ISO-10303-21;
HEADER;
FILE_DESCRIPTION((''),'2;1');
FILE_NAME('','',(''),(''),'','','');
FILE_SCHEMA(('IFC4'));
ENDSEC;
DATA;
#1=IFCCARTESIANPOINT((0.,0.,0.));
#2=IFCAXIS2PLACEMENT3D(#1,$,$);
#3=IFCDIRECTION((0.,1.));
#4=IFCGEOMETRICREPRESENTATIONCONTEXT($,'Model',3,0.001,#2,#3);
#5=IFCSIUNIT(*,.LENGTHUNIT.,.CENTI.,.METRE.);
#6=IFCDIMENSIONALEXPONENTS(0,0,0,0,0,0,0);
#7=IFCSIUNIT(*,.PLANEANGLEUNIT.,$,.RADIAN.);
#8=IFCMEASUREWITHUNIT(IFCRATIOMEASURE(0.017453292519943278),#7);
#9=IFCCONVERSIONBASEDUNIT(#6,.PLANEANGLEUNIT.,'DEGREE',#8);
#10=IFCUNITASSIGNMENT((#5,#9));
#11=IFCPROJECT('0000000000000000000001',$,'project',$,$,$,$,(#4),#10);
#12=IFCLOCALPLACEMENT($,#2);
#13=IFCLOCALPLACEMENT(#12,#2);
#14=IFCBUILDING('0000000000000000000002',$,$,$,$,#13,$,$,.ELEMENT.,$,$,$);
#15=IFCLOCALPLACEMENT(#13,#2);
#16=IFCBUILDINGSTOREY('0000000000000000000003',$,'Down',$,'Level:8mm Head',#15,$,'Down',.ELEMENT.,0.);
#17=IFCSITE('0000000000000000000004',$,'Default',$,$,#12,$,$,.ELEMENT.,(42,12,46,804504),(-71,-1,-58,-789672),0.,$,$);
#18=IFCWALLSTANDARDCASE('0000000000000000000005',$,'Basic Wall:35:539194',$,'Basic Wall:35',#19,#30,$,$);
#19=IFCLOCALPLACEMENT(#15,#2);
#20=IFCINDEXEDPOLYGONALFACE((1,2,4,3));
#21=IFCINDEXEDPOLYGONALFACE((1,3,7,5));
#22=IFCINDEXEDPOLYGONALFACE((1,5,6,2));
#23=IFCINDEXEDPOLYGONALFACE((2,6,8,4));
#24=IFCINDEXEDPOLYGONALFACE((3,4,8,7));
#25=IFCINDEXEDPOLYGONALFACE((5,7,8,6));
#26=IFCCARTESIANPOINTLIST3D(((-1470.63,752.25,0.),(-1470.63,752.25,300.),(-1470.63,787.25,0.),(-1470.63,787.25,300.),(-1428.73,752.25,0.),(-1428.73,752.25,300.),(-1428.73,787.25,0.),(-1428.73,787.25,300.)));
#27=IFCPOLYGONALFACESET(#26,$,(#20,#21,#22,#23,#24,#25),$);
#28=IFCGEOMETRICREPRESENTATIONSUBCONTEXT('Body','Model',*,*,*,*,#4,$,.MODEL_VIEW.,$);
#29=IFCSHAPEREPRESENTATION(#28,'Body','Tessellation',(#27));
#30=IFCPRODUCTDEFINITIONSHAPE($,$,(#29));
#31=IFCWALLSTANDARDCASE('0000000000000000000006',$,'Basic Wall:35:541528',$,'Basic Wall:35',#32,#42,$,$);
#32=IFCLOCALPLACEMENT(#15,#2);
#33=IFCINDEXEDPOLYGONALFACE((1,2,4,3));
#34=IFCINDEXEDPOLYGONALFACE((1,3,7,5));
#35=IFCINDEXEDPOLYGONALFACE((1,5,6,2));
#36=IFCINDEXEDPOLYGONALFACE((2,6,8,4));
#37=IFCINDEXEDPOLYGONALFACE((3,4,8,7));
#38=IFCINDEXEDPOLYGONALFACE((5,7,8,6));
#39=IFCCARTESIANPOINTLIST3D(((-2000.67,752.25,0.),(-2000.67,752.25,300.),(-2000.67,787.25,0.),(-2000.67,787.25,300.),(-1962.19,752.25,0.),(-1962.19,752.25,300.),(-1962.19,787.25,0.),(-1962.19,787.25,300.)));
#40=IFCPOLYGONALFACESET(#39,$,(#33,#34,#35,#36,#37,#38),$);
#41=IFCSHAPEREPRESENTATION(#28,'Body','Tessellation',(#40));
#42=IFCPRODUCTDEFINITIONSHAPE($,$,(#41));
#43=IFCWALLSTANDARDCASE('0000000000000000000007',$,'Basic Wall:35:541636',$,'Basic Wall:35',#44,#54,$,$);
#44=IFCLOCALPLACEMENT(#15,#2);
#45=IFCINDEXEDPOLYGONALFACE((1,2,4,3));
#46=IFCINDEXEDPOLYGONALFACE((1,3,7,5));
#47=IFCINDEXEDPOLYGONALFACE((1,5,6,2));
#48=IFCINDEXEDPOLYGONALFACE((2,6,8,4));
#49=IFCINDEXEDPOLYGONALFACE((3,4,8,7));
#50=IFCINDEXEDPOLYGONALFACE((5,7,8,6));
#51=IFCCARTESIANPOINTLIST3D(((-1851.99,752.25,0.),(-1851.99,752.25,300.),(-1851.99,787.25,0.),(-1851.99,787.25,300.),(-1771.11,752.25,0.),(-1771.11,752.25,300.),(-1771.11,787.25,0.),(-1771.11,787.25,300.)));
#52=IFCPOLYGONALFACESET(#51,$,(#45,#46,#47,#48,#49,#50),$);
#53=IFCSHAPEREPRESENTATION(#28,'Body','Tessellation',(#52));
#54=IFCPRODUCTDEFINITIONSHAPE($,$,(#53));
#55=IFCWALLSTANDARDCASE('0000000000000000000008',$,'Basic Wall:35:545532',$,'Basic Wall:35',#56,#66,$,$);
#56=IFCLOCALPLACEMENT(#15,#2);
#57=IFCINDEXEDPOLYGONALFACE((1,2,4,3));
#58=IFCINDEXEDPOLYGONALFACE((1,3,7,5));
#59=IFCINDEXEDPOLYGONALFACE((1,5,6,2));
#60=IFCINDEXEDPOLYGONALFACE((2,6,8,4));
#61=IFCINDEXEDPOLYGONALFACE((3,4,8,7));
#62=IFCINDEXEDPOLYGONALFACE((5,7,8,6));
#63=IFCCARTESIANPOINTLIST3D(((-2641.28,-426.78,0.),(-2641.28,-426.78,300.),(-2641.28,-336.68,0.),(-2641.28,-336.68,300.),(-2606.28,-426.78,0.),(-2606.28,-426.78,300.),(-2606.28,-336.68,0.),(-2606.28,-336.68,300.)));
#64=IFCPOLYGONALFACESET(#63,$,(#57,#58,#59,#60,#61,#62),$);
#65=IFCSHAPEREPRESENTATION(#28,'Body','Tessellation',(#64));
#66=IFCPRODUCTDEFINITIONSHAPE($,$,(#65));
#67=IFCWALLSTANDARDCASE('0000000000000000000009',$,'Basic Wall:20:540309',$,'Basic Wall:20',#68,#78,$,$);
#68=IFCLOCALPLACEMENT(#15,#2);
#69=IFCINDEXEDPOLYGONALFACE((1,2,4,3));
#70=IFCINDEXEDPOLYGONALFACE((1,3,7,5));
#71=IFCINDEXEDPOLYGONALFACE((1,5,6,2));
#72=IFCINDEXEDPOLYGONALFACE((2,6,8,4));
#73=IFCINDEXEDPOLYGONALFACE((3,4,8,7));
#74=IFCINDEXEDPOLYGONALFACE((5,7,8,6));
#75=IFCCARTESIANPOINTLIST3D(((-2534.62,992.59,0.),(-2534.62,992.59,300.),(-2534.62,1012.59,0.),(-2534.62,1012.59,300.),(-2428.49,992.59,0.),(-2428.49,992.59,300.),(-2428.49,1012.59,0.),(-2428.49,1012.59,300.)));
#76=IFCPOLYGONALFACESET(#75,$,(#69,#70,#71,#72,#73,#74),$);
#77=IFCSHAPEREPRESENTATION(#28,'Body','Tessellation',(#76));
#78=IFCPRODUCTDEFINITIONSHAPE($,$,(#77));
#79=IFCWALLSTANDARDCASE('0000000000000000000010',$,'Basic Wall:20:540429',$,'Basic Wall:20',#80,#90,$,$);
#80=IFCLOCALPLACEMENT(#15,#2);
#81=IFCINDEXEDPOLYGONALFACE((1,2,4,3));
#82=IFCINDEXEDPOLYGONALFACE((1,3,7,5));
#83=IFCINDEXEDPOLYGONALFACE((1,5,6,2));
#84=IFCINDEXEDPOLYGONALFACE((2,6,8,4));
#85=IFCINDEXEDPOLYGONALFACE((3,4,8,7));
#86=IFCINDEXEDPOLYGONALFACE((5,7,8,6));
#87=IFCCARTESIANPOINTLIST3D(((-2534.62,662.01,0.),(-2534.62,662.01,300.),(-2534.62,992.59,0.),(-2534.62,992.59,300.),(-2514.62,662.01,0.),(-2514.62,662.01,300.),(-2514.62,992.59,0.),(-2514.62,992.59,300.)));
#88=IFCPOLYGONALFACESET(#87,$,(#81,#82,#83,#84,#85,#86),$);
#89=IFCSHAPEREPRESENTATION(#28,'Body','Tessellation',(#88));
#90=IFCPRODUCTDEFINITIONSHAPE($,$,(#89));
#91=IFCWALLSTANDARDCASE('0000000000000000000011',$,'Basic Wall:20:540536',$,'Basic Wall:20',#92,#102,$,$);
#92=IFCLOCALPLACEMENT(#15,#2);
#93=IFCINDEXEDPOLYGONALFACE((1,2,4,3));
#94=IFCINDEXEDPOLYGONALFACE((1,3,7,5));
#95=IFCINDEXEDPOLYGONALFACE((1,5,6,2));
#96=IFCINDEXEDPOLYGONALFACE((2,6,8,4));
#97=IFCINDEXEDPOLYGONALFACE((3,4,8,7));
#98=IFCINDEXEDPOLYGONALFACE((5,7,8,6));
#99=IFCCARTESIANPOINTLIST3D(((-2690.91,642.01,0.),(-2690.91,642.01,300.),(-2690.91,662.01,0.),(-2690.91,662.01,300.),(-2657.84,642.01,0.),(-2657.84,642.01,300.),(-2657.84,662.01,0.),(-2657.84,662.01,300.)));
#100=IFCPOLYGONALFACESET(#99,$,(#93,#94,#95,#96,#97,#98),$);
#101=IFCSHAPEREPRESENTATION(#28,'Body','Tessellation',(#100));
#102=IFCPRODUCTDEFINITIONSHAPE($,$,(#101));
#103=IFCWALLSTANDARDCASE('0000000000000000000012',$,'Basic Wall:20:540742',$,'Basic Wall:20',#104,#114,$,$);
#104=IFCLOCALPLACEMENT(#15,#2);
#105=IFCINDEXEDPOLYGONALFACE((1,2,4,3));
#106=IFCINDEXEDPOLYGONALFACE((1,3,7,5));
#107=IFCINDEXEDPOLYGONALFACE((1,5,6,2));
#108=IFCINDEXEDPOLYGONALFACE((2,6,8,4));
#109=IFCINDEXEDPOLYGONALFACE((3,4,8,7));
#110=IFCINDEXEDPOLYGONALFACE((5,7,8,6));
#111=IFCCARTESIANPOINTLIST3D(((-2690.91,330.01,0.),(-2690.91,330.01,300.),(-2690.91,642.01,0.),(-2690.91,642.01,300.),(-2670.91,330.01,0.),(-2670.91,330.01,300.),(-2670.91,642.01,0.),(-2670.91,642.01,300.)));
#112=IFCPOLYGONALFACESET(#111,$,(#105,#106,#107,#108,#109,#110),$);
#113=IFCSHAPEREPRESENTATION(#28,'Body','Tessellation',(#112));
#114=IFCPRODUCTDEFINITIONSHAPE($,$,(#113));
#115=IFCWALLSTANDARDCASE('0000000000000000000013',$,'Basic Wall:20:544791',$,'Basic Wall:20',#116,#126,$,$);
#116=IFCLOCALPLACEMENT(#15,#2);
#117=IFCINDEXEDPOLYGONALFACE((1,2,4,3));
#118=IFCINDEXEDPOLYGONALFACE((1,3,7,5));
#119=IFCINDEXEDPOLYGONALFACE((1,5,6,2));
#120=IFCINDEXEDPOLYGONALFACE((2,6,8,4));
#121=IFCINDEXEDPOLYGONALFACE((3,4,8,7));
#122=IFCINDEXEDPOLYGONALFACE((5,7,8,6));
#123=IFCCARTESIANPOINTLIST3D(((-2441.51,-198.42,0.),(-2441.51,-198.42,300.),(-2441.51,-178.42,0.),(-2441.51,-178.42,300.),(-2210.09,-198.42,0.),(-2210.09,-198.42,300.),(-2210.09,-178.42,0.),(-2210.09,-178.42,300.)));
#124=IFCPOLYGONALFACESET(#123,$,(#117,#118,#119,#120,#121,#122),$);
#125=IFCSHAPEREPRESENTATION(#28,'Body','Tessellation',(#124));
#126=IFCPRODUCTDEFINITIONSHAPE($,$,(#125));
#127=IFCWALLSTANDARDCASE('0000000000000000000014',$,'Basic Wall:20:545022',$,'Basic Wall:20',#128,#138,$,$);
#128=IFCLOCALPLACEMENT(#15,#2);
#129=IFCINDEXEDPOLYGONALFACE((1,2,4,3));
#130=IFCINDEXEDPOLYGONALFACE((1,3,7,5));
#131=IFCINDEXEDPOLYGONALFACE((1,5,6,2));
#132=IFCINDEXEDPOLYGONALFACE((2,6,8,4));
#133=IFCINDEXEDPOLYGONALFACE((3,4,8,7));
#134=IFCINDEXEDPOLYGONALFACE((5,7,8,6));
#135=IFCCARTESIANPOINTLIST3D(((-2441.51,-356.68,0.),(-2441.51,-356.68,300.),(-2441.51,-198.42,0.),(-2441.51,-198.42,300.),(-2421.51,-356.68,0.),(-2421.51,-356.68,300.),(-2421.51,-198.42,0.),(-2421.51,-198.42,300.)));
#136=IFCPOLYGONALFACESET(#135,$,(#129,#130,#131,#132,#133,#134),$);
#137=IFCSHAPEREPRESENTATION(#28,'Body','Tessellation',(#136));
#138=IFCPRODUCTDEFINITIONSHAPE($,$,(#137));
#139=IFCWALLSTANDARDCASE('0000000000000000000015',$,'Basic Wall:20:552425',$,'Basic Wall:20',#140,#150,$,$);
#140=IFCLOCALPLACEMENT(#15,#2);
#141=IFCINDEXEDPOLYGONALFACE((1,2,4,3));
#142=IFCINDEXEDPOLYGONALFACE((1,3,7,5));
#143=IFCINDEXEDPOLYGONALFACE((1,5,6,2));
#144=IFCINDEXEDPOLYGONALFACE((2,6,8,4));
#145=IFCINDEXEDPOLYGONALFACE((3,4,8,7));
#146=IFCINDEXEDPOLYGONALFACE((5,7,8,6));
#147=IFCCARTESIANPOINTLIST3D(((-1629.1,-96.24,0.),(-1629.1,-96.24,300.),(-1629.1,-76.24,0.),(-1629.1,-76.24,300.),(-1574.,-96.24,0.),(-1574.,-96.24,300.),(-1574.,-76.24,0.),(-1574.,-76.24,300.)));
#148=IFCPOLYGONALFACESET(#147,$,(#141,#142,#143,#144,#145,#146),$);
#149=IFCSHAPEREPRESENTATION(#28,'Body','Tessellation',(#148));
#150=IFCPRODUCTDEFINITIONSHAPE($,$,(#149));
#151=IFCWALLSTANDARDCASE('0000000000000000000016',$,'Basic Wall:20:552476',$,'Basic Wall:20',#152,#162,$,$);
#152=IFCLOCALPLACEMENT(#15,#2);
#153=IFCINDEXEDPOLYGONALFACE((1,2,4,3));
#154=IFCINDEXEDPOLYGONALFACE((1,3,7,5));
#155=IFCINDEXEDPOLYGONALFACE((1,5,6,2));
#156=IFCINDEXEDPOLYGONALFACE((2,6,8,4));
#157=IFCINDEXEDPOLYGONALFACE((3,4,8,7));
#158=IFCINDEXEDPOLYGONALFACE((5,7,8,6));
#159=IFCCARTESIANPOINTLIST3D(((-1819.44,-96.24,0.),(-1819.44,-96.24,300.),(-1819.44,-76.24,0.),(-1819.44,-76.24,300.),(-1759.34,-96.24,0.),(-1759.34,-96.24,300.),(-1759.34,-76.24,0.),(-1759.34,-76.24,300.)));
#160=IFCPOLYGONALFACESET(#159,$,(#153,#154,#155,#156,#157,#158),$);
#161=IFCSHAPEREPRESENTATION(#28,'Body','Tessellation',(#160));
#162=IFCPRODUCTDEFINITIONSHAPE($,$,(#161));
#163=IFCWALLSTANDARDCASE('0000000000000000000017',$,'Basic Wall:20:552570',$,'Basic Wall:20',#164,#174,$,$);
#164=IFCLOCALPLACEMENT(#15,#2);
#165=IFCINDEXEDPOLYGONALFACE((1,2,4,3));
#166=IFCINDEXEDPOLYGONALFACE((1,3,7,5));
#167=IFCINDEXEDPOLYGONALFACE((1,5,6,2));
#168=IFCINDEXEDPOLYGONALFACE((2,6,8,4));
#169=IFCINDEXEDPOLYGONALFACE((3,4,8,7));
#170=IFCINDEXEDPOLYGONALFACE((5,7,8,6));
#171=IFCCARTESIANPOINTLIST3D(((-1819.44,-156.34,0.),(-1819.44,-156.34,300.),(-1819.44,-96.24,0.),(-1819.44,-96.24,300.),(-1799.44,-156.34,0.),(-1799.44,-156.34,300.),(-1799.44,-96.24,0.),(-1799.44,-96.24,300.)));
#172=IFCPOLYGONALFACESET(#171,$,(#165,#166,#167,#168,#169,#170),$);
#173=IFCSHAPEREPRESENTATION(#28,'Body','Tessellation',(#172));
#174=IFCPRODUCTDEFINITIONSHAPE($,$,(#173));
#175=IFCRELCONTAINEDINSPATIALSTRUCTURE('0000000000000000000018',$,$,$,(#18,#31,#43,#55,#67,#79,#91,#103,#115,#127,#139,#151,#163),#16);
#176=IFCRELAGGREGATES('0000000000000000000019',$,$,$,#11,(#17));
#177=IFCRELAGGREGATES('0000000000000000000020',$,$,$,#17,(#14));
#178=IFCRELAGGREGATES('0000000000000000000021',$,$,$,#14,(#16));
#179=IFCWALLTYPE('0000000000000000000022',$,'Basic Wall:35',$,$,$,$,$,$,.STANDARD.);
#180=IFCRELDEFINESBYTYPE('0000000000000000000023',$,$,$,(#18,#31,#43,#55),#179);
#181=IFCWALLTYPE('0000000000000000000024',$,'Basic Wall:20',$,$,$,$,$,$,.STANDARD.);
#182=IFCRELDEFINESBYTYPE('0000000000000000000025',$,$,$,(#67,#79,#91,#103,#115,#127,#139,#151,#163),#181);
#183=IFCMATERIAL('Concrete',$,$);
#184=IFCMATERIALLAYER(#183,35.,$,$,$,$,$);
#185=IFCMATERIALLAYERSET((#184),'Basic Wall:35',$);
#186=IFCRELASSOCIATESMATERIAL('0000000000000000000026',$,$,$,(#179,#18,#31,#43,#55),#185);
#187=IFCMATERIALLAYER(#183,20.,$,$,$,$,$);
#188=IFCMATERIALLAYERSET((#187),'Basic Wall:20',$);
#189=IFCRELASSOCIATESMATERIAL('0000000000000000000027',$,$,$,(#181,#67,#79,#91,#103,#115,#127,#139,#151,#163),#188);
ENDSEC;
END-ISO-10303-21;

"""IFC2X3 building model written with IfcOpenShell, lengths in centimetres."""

from ifc_helpers import new_model, entity, si_unit, converted_unit, direction, frame, frame_2d, origin, place, context, subcontext, project, spatial, rectangle, extrude, material, layer, layer_set, layer_usage, type_object, element, save


model = new_model("IFC2X3")

# Units and contexts
model_context = context("Model", 3, precision=0.001, world=origin(), true_north=direction((0.0, 1.0)))
body_context = subcontext(model_context, "Body", "Model", "MODEL_VIEW")
ifc_project = project(units=[si_unit("LENGTHUNIT", "METRE", prefix="CENTI"), converted_unit("PLANEANGLEUNIT", "DEGREE", entity("IfcRatioMeasure", 0.017453292519943278), si_unit("PLANEANGLEUNIT", "RADIAN"), dimensions=[0, 0, 0, 0, 0, 0, 0])], contexts=[model_context])

# Site, building, storey
site_placement = place(None, origin())
site = spatial("IfcSite", under=ifc_project, at=site_placement, Name="Default", CompositionType="ELEMENT", RefLatitude=(42, 12, 46, 804504), RefLongitude=(-71, -1, -58, -789672), RefElevation=0.0)
building_placement = place(site_placement, origin())
building = spatial("IfcBuilding", under=site, at=building_placement, CompositionType="ELEMENT")
storey_placement = place(building_placement, origin())
storey = spatial("IfcBuildingStorey", under=building, at=storey_placement, Name="Down", ObjectType="Level:8mm Head", LongName="Down", CompositionType="ELEMENT", Elevation=0.0)

# Walls
ifc_material = material(Name="Concrete")
ifc_layer_1 = layer(ifc_material, 35.0)
ifc_layer_set_1 = layer_set([ifc_layer_1], Name="Basic Wall:35")
ifc_layer_usage_1 = layer_usage(ifc_layer_set_1, "AXIS2", "POSITIVE", -17.5)
wall_type_1 = type_object("IfcWallType", Name="Basic Wall:35", PredefinedType="STANDARD", material=ifc_layer_set_1)
wall_1_placement = place(storey_placement, frame((-1470.63, 769.75, 0.0)))
element("IfcWallStandardCase", 1, at=wall_1_placement, inside=storey, type_object=wall_type_1, material=ifc_layer_usage_1, Name="Basic Wall:35:539194", ObjectType="Basic Wall:35", context=body_context, shape_type="SweptSolid", body=[
    extrude(rectangle(XDim=41.9, YDim=35.0, at=frame_2d((20.95, 0.0), x_axis=(-1.0, 0.0))), origin(), (0.0, 0.0, 1.0), 300.0),
])
ifc_layer_usage_2 = layer_usage(ifc_layer_set_1, "AXIS2", "POSITIVE", -17.5)
wall_2_placement = place(storey_placement, frame((-2000.67, 769.75, 0.0)))
element("IfcWallStandardCase", 2, at=wall_2_placement, inside=storey, type_object=wall_type_1, material=ifc_layer_usage_2, Name="Basic Wall:35:541528", ObjectType="Basic Wall:35", context=body_context, shape_type="SweptSolid", body=[
    extrude(rectangle(XDim=38.49, YDim=35.0, at=frame_2d((19.24, 0.0), x_axis=(-1.0, 0.0))), origin(), (0.0, 0.0, 1.0), 300.0),
])
ifc_layer_usage_3 = layer_usage(ifc_layer_set_1, "AXIS2", "POSITIVE", -17.5)
wall_3_placement = place(storey_placement, frame((-1851.99, 769.75, 0.0)))
element("IfcWallStandardCase", 3, at=wall_3_placement, inside=storey, type_object=wall_type_1, material=ifc_layer_usage_3, Name="Basic Wall:35:541636", ObjectType="Basic Wall:35", context=body_context, shape_type="SweptSolid", body=[
    extrude(rectangle(XDim=80.88, YDim=35.0, at=frame_2d((40.44, 0.0), x_axis=(-1.0, 0.0))), origin(), (0.0, 0.0, 1.0), 300.0),
])
ifc_layer_usage_4 = layer_usage(ifc_layer_set_1, "AXIS2", "NEGATIVE", 17.5)
wall_4_placement = place(storey_placement, frame((-2623.78, -336.68, 0.0), z_axis=(0.0, 0.0, 1.0), x_axis=(0.0, -1.0, 0.0)))
element("IfcWallStandardCase", 4, at=wall_4_placement, inside=storey, type_object=wall_type_1, material=ifc_layer_usage_4, Name="Basic Wall:35:545532", ObjectType="Basic Wall:35", context=body_context, shape_type="SweptSolid", body=[
    extrude(rectangle(XDim=90.1, YDim=35.0, at=frame_2d((45.05, 0.0), x_axis=(-1.0, 0.0))), origin(), (0.0, 0.0, 1.0), 300.0),
])
ifc_layer_2 = layer(ifc_material, 20.0)
ifc_layer_set_2 = layer_set([ifc_layer_2], Name="Basic Wall:20")
ifc_layer_usage_5 = layer_usage(ifc_layer_set_2, "AXIS2", "POSITIVE", -10.0)
wall_type_2 = type_object("IfcWallType", Name="Basic Wall:20", PredefinedType="STANDARD", material=ifc_layer_set_2)
wall_5_placement = place(storey_placement, frame((-2428.49, 1002.59, 0.0), z_axis=(0.0, 0.0, 1.0), x_axis=(-1.0, 0.0, 0.0)))
element("IfcWallStandardCase", 5, at=wall_5_placement, inside=storey, type_object=wall_type_2, material=ifc_layer_usage_5, Name="Basic Wall:20:540309", ObjectType="Basic Wall:20", context=body_context, shape_type="SweptSolid", body=[
    extrude(rectangle(XDim=106.13, YDim=20.0, at=frame_2d((53.07, 0.0), x_axis=(-1.0, 0.0))), origin(), (0.0, 0.0, 1.0), 300.0),
])
ifc_layer_usage_6 = layer_usage(ifc_layer_set_2, "AXIS2", "POSITIVE", -10.0)
wall_6_placement = place(storey_placement, frame((-2524.62, 992.59, 0.0), z_axis=(0.0, 0.0, 1.0), x_axis=(0.0, -1.0, 0.0)))
element("IfcWallStandardCase", 6, at=wall_6_placement, inside=storey, type_object=wall_type_2, material=ifc_layer_usage_6, Name="Basic Wall:20:540429", ObjectType="Basic Wall:20", context=body_context, shape_type="SweptSolid", body=[
    extrude(rectangle(XDim=330.59, YDim=20.0, at=frame_2d((165.29, 0.0), x_axis=(-1.0, 0.0))), origin(), (0.0, 0.0, 1.0), 300.0),
])
ifc_layer_usage_7 = layer_usage(ifc_layer_set_2, "AXIS2", "NEGATIVE", 10.0)
wall_7_placement = place(storey_placement, frame((-2657.84, 652.01, 0.0), z_axis=(0.0, 0.0, 1.0), x_axis=(-1.0, 0.0, 0.0)))
element("IfcWallStandardCase", 7, at=wall_7_placement, inside=storey, type_object=wall_type_2, material=ifc_layer_usage_7, Name="Basic Wall:20:540536", ObjectType="Basic Wall:20", context=body_context, shape_type="SweptSolid", body=[
    extrude(rectangle(XDim=33.07, YDim=20.0, at=frame_2d((16.53, 0.0), x_axis=(-1.0, 0.0))), origin(), (0.0, 0.0, 1.0), 300.0),
])
ifc_layer_usage_8 = layer_usage(ifc_layer_set_2, "AXIS2", "POSITIVE", -10.0)
wall_8_placement = place(storey_placement, frame((-2680.91, 642.01, 0.0), z_axis=(0.0, 0.0, 1.0), x_axis=(0.0, -1.0, 0.0)))
element("IfcWallStandardCase", 8, at=wall_8_placement, inside=storey, type_object=wall_type_2, material=ifc_layer_usage_8, Name="Basic Wall:20:540742", ObjectType="Basic Wall:20", context=body_context, shape_type="SweptSolid", body=[
    extrude(rectangle(XDim=312.0, YDim=20.0, at=frame_2d((156.0, 0.0), x_axis=(-1.0, 0.0))), origin(), (0.0, 0.0, 1.0), 300.0),
])
ifc_layer_usage_9 = layer_usage(ifc_layer_set_2, "AXIS2", "NEGATIVE", 10.0)
wall_9_placement = place(storey_placement, frame((-2210.09, -188.42, 0.0), z_axis=(0.0, 0.0, 1.0), x_axis=(-1.0, 0.0, 0.0)))
element("IfcWallStandardCase", 9, at=wall_9_placement, inside=storey, type_object=wall_type_2, material=ifc_layer_usage_9, Name="Basic Wall:20:544791", ObjectType="Basic Wall:20", context=body_context, shape_type="SweptSolid", body=[
    extrude(rectangle(XDim=231.41, YDim=20.0, at=frame_2d((115.71, 0.0), x_axis=(-1.0, 0.0))), origin(), (0.0, 0.0, 1.0), 300.0),
])
ifc_layer_usage_10 = layer_usage(ifc_layer_set_2, "AXIS2", "POSITIVE", -10.0)
wall_10_placement = place(storey_placement, frame((-2431.51, -198.42, 0.0), z_axis=(0.0, 0.0, 1.0), x_axis=(0.0, -1.0, 0.0)))
element("IfcWallStandardCase", 10, at=wall_10_placement, inside=storey, type_object=wall_type_2, material=ifc_layer_usage_10, Name="Basic Wall:20:545022", ObjectType="Basic Wall:20", context=body_context, shape_type="SweptSolid", body=[
    extrude(rectangle(XDim=158.26, YDim=20.0, at=frame_2d((79.13, 0.0), x_axis=(-1.0, 0.0))), origin(), (0.0, 0.0, 1.0), 300.0),
])
ifc_layer_usage_11 = layer_usage(ifc_layer_set_2, "AXIS2", "NEGATIVE", 10.0)
wall_11_placement = place(storey_placement, frame((-1574.0, -86.24, 0.0), z_axis=(0.0, 0.0, 1.0), x_axis=(-1.0, 0.0, 0.0)))
element("IfcWallStandardCase", 11, at=wall_11_placement, inside=storey, type_object=wall_type_2, material=ifc_layer_usage_11, Name="Basic Wall:20:552425", ObjectType="Basic Wall:20", context=body_context, shape_type="SweptSolid", body=[
    extrude(rectangle(XDim=55.1, YDim=20.0, at=frame_2d((27.55, 0.0), x_axis=(-1.0, 0.0))), origin(), (0.0, 0.0, 1.0), 300.0),
])
ifc_layer_usage_12 = layer_usage(ifc_layer_set_2, "AXIS2", "NEGATIVE", 10.0)
wall_12_placement = place(storey_placement, frame((-1759.34, -86.24, 0.0), z_axis=(0.0, 0.0, 1.0), x_axis=(-1.0, 0.0, 0.0)))
element("IfcWallStandardCase", 12, at=wall_12_placement, inside=storey, type_object=wall_type_2, material=ifc_layer_usage_12, Name="Basic Wall:20:552476", ObjectType="Basic Wall:20", context=body_context, shape_type="SweptSolid", body=[
    extrude(rectangle(XDim=60.1, YDim=20.0, at=frame_2d((30.05, 0.0), x_axis=(-1.0, 0.0))), origin(), (0.0, 0.0, 1.0), 300.0),
])
ifc_layer_usage_13 = layer_usage(ifc_layer_set_2, "AXIS2", "POSITIVE", -10.0)
wall_13_placement = place(storey_placement, frame((-1809.44, -96.24, 0.0), z_axis=(0.0, 0.0, 1.0), x_axis=(0.0, -1.0, 0.0)))
element("IfcWallStandardCase", 13, at=wall_13_placement, inside=storey, type_object=wall_type_2, material=ifc_layer_usage_13, Name="Basic Wall:20:552570", ObjectType="Basic Wall:20", context=body_context, shape_type="SweptSolid", body=[
    extrude(rectangle(XDim=60.1, YDim=20.0, at=frame_2d((30.05, 0.0), x_axis=(-1.0, 0.0))), origin(), (0.0, 0.0, 1.0), 300.0),
])

save(model, "model.ifc")
